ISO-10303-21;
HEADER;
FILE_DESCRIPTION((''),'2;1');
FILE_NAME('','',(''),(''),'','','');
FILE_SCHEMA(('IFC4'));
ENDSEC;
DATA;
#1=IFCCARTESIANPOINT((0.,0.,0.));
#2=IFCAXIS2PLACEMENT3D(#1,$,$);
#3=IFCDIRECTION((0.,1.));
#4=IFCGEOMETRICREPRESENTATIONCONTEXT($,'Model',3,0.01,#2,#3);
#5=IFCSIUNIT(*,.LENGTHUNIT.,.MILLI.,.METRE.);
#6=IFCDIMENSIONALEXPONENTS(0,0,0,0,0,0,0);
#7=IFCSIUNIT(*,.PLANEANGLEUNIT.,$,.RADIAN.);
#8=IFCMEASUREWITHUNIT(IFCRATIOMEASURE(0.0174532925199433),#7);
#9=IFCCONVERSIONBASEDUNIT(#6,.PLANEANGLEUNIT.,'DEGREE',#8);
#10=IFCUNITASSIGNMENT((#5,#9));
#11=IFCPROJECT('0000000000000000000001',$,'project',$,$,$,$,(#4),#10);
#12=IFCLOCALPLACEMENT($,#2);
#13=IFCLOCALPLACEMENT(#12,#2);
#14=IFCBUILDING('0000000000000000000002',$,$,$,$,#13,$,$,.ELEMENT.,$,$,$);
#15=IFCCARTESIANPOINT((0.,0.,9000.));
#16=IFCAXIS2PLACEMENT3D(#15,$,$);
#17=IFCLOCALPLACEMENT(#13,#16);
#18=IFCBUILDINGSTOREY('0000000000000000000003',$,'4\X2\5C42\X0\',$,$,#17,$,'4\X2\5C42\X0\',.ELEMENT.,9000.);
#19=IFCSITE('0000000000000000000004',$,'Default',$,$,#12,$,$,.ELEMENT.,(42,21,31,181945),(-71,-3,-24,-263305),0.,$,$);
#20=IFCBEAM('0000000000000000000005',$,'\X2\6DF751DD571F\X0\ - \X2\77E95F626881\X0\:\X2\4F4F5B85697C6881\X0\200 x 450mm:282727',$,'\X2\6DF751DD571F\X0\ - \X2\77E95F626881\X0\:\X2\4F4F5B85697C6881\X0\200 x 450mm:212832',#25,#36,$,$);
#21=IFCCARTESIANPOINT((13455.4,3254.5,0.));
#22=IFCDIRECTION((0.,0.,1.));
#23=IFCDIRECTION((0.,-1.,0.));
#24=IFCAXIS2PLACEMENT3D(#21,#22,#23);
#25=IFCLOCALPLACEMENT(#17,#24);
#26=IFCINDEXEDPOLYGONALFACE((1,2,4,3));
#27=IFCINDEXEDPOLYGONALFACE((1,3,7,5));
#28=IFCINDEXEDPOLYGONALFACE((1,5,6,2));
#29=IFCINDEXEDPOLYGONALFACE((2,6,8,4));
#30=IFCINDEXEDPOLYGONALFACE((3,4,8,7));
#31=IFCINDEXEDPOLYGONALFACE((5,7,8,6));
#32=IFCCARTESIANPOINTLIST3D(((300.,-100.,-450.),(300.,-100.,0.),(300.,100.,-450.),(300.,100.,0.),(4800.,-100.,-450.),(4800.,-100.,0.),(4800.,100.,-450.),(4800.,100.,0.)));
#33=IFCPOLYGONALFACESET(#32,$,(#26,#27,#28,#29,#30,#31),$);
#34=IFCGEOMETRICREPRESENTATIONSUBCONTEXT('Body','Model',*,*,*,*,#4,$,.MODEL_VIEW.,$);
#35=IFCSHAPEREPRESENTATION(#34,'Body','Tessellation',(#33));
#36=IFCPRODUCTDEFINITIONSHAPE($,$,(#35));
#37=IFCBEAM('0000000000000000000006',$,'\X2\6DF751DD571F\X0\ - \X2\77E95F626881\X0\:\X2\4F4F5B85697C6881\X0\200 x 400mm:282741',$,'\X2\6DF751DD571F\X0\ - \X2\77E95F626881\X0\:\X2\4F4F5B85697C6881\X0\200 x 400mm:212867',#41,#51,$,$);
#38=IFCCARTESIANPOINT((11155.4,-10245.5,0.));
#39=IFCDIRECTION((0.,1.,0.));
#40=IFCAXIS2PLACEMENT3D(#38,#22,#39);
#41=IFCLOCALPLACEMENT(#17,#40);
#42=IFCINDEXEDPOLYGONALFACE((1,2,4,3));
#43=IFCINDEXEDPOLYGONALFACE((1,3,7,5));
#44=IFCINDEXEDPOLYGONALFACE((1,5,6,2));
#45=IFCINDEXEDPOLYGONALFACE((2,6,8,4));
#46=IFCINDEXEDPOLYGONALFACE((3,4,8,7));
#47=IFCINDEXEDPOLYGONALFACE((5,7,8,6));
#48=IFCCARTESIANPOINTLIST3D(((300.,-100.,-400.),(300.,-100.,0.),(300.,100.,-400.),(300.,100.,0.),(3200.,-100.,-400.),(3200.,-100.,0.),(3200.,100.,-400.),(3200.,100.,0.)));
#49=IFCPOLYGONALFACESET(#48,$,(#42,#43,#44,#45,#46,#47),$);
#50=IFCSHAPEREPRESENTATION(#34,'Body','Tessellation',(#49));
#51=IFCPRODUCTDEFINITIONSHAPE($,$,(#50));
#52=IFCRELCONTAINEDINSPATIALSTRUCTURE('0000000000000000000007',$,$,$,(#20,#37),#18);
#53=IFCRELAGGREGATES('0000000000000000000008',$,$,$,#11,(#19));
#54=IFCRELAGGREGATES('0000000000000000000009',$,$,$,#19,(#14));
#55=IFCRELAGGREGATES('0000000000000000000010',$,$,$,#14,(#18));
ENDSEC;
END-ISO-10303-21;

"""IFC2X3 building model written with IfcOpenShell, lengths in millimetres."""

from ifc_helpers import new_model, entity, si_unit, converted_unit, direction, frame, frame_2d, origin, origin_2d_with_axis, place, context, subcontext, project, spatial, rectangle, extrude, element, save


model = new_model("IFC2X3")

# Units and contexts
model_context = context("Model", 3, precision=0.01, world=origin(), true_north=direction((0.0, 1.0)))
body_context = subcontext(model_context, "Body", "Model", "MODEL_VIEW")
ifc_project = project(units=[si_unit("LENGTHUNIT", "METRE", prefix="MILLI"), converted_unit("PLANEANGLEUNIT", "DEGREE", entity("IfcRatioMeasure", 0.0174532925199433), si_unit("PLANEANGLEUNIT", "RADIAN"), dimensions=[0, 0, 0, 0, 0, 0, 0])], contexts=[model_context])

# Site, building, storey
site_placement = place(None, origin())
site = spatial("IfcSite", under=ifc_project, at=site_placement, Name="Default", CompositionType="ELEMENT", RefLatitude=(42, 21, 31, 181945), RefLongitude=(-71, -3, -24, -263305), RefElevation=0.0)
building_placement = place(site_placement, origin())
building = spatial("IfcBuilding", under=site, at=building_placement, CompositionType="ELEMENT")
storey_placement = place(building_placement, frame((0.0, 0.0, 9000.0)))
storey = spatial("IfcBuildingStorey", under=building, at=storey_placement, Name="4层", LongName="4层", CompositionType="ELEMENT", Elevation=9000.0)

# Beams
beam_1_placement = place(storey_placement, frame((13455.4, 3254.5, 0.0), z_axis=(0.0, 0.0, 1.0), x_axis=(0.0, -1.0, 0.0)))
element("IfcBeam", 1, at=beam_1_placement, inside=storey, Name="混凝土 - 矩形梁:住宅楼梁200 x 450mm:282727", ObjectType="混凝土 - 矩形梁:住宅楼梁200 x 450mm:212832", context=body_context, shape_type="SweptSolid", body=[
    extrude(rectangle(XDim=450.0, YDim=200.0, at=origin_2d_with_axis()), frame((300.0, 0.0, -225.0), z_axis=(1.0, 0.0, 0.0), x_axis=(0.0, 0.0, -1.0)), (0.0, 0.0, 1.0), 4500.0),
])
beam_2_placement = place(storey_placement, frame((11155.4, -10245.5, 0.0), z_axis=(0.0, 0.0, 1.0), x_axis=(0.0, 1.0, 0.0)))
element("IfcBeam", 2, at=beam_2_placement, inside=storey, Name="混凝土 - 矩形梁:住宅楼梁200 x 400mm:282741", ObjectType="混凝土 - 矩形梁:住宅楼梁200 x 400mm:212867", context=body_context, shape_type="SweptSolid", body=[
    extrude(rectangle(XDim=400.0, YDim=200.0, at=frame_2d((0.0, 0.0), x_axis=(1.0, 0.0))), frame((300.0, 0.0, -200.0), z_axis=(1.0, 0.0, 0.0), x_axis=(0.0, 0.0, -1.0)), (0.0, 0.0, 1.0), 2900.0),
])

save(model, "model.ifc")
